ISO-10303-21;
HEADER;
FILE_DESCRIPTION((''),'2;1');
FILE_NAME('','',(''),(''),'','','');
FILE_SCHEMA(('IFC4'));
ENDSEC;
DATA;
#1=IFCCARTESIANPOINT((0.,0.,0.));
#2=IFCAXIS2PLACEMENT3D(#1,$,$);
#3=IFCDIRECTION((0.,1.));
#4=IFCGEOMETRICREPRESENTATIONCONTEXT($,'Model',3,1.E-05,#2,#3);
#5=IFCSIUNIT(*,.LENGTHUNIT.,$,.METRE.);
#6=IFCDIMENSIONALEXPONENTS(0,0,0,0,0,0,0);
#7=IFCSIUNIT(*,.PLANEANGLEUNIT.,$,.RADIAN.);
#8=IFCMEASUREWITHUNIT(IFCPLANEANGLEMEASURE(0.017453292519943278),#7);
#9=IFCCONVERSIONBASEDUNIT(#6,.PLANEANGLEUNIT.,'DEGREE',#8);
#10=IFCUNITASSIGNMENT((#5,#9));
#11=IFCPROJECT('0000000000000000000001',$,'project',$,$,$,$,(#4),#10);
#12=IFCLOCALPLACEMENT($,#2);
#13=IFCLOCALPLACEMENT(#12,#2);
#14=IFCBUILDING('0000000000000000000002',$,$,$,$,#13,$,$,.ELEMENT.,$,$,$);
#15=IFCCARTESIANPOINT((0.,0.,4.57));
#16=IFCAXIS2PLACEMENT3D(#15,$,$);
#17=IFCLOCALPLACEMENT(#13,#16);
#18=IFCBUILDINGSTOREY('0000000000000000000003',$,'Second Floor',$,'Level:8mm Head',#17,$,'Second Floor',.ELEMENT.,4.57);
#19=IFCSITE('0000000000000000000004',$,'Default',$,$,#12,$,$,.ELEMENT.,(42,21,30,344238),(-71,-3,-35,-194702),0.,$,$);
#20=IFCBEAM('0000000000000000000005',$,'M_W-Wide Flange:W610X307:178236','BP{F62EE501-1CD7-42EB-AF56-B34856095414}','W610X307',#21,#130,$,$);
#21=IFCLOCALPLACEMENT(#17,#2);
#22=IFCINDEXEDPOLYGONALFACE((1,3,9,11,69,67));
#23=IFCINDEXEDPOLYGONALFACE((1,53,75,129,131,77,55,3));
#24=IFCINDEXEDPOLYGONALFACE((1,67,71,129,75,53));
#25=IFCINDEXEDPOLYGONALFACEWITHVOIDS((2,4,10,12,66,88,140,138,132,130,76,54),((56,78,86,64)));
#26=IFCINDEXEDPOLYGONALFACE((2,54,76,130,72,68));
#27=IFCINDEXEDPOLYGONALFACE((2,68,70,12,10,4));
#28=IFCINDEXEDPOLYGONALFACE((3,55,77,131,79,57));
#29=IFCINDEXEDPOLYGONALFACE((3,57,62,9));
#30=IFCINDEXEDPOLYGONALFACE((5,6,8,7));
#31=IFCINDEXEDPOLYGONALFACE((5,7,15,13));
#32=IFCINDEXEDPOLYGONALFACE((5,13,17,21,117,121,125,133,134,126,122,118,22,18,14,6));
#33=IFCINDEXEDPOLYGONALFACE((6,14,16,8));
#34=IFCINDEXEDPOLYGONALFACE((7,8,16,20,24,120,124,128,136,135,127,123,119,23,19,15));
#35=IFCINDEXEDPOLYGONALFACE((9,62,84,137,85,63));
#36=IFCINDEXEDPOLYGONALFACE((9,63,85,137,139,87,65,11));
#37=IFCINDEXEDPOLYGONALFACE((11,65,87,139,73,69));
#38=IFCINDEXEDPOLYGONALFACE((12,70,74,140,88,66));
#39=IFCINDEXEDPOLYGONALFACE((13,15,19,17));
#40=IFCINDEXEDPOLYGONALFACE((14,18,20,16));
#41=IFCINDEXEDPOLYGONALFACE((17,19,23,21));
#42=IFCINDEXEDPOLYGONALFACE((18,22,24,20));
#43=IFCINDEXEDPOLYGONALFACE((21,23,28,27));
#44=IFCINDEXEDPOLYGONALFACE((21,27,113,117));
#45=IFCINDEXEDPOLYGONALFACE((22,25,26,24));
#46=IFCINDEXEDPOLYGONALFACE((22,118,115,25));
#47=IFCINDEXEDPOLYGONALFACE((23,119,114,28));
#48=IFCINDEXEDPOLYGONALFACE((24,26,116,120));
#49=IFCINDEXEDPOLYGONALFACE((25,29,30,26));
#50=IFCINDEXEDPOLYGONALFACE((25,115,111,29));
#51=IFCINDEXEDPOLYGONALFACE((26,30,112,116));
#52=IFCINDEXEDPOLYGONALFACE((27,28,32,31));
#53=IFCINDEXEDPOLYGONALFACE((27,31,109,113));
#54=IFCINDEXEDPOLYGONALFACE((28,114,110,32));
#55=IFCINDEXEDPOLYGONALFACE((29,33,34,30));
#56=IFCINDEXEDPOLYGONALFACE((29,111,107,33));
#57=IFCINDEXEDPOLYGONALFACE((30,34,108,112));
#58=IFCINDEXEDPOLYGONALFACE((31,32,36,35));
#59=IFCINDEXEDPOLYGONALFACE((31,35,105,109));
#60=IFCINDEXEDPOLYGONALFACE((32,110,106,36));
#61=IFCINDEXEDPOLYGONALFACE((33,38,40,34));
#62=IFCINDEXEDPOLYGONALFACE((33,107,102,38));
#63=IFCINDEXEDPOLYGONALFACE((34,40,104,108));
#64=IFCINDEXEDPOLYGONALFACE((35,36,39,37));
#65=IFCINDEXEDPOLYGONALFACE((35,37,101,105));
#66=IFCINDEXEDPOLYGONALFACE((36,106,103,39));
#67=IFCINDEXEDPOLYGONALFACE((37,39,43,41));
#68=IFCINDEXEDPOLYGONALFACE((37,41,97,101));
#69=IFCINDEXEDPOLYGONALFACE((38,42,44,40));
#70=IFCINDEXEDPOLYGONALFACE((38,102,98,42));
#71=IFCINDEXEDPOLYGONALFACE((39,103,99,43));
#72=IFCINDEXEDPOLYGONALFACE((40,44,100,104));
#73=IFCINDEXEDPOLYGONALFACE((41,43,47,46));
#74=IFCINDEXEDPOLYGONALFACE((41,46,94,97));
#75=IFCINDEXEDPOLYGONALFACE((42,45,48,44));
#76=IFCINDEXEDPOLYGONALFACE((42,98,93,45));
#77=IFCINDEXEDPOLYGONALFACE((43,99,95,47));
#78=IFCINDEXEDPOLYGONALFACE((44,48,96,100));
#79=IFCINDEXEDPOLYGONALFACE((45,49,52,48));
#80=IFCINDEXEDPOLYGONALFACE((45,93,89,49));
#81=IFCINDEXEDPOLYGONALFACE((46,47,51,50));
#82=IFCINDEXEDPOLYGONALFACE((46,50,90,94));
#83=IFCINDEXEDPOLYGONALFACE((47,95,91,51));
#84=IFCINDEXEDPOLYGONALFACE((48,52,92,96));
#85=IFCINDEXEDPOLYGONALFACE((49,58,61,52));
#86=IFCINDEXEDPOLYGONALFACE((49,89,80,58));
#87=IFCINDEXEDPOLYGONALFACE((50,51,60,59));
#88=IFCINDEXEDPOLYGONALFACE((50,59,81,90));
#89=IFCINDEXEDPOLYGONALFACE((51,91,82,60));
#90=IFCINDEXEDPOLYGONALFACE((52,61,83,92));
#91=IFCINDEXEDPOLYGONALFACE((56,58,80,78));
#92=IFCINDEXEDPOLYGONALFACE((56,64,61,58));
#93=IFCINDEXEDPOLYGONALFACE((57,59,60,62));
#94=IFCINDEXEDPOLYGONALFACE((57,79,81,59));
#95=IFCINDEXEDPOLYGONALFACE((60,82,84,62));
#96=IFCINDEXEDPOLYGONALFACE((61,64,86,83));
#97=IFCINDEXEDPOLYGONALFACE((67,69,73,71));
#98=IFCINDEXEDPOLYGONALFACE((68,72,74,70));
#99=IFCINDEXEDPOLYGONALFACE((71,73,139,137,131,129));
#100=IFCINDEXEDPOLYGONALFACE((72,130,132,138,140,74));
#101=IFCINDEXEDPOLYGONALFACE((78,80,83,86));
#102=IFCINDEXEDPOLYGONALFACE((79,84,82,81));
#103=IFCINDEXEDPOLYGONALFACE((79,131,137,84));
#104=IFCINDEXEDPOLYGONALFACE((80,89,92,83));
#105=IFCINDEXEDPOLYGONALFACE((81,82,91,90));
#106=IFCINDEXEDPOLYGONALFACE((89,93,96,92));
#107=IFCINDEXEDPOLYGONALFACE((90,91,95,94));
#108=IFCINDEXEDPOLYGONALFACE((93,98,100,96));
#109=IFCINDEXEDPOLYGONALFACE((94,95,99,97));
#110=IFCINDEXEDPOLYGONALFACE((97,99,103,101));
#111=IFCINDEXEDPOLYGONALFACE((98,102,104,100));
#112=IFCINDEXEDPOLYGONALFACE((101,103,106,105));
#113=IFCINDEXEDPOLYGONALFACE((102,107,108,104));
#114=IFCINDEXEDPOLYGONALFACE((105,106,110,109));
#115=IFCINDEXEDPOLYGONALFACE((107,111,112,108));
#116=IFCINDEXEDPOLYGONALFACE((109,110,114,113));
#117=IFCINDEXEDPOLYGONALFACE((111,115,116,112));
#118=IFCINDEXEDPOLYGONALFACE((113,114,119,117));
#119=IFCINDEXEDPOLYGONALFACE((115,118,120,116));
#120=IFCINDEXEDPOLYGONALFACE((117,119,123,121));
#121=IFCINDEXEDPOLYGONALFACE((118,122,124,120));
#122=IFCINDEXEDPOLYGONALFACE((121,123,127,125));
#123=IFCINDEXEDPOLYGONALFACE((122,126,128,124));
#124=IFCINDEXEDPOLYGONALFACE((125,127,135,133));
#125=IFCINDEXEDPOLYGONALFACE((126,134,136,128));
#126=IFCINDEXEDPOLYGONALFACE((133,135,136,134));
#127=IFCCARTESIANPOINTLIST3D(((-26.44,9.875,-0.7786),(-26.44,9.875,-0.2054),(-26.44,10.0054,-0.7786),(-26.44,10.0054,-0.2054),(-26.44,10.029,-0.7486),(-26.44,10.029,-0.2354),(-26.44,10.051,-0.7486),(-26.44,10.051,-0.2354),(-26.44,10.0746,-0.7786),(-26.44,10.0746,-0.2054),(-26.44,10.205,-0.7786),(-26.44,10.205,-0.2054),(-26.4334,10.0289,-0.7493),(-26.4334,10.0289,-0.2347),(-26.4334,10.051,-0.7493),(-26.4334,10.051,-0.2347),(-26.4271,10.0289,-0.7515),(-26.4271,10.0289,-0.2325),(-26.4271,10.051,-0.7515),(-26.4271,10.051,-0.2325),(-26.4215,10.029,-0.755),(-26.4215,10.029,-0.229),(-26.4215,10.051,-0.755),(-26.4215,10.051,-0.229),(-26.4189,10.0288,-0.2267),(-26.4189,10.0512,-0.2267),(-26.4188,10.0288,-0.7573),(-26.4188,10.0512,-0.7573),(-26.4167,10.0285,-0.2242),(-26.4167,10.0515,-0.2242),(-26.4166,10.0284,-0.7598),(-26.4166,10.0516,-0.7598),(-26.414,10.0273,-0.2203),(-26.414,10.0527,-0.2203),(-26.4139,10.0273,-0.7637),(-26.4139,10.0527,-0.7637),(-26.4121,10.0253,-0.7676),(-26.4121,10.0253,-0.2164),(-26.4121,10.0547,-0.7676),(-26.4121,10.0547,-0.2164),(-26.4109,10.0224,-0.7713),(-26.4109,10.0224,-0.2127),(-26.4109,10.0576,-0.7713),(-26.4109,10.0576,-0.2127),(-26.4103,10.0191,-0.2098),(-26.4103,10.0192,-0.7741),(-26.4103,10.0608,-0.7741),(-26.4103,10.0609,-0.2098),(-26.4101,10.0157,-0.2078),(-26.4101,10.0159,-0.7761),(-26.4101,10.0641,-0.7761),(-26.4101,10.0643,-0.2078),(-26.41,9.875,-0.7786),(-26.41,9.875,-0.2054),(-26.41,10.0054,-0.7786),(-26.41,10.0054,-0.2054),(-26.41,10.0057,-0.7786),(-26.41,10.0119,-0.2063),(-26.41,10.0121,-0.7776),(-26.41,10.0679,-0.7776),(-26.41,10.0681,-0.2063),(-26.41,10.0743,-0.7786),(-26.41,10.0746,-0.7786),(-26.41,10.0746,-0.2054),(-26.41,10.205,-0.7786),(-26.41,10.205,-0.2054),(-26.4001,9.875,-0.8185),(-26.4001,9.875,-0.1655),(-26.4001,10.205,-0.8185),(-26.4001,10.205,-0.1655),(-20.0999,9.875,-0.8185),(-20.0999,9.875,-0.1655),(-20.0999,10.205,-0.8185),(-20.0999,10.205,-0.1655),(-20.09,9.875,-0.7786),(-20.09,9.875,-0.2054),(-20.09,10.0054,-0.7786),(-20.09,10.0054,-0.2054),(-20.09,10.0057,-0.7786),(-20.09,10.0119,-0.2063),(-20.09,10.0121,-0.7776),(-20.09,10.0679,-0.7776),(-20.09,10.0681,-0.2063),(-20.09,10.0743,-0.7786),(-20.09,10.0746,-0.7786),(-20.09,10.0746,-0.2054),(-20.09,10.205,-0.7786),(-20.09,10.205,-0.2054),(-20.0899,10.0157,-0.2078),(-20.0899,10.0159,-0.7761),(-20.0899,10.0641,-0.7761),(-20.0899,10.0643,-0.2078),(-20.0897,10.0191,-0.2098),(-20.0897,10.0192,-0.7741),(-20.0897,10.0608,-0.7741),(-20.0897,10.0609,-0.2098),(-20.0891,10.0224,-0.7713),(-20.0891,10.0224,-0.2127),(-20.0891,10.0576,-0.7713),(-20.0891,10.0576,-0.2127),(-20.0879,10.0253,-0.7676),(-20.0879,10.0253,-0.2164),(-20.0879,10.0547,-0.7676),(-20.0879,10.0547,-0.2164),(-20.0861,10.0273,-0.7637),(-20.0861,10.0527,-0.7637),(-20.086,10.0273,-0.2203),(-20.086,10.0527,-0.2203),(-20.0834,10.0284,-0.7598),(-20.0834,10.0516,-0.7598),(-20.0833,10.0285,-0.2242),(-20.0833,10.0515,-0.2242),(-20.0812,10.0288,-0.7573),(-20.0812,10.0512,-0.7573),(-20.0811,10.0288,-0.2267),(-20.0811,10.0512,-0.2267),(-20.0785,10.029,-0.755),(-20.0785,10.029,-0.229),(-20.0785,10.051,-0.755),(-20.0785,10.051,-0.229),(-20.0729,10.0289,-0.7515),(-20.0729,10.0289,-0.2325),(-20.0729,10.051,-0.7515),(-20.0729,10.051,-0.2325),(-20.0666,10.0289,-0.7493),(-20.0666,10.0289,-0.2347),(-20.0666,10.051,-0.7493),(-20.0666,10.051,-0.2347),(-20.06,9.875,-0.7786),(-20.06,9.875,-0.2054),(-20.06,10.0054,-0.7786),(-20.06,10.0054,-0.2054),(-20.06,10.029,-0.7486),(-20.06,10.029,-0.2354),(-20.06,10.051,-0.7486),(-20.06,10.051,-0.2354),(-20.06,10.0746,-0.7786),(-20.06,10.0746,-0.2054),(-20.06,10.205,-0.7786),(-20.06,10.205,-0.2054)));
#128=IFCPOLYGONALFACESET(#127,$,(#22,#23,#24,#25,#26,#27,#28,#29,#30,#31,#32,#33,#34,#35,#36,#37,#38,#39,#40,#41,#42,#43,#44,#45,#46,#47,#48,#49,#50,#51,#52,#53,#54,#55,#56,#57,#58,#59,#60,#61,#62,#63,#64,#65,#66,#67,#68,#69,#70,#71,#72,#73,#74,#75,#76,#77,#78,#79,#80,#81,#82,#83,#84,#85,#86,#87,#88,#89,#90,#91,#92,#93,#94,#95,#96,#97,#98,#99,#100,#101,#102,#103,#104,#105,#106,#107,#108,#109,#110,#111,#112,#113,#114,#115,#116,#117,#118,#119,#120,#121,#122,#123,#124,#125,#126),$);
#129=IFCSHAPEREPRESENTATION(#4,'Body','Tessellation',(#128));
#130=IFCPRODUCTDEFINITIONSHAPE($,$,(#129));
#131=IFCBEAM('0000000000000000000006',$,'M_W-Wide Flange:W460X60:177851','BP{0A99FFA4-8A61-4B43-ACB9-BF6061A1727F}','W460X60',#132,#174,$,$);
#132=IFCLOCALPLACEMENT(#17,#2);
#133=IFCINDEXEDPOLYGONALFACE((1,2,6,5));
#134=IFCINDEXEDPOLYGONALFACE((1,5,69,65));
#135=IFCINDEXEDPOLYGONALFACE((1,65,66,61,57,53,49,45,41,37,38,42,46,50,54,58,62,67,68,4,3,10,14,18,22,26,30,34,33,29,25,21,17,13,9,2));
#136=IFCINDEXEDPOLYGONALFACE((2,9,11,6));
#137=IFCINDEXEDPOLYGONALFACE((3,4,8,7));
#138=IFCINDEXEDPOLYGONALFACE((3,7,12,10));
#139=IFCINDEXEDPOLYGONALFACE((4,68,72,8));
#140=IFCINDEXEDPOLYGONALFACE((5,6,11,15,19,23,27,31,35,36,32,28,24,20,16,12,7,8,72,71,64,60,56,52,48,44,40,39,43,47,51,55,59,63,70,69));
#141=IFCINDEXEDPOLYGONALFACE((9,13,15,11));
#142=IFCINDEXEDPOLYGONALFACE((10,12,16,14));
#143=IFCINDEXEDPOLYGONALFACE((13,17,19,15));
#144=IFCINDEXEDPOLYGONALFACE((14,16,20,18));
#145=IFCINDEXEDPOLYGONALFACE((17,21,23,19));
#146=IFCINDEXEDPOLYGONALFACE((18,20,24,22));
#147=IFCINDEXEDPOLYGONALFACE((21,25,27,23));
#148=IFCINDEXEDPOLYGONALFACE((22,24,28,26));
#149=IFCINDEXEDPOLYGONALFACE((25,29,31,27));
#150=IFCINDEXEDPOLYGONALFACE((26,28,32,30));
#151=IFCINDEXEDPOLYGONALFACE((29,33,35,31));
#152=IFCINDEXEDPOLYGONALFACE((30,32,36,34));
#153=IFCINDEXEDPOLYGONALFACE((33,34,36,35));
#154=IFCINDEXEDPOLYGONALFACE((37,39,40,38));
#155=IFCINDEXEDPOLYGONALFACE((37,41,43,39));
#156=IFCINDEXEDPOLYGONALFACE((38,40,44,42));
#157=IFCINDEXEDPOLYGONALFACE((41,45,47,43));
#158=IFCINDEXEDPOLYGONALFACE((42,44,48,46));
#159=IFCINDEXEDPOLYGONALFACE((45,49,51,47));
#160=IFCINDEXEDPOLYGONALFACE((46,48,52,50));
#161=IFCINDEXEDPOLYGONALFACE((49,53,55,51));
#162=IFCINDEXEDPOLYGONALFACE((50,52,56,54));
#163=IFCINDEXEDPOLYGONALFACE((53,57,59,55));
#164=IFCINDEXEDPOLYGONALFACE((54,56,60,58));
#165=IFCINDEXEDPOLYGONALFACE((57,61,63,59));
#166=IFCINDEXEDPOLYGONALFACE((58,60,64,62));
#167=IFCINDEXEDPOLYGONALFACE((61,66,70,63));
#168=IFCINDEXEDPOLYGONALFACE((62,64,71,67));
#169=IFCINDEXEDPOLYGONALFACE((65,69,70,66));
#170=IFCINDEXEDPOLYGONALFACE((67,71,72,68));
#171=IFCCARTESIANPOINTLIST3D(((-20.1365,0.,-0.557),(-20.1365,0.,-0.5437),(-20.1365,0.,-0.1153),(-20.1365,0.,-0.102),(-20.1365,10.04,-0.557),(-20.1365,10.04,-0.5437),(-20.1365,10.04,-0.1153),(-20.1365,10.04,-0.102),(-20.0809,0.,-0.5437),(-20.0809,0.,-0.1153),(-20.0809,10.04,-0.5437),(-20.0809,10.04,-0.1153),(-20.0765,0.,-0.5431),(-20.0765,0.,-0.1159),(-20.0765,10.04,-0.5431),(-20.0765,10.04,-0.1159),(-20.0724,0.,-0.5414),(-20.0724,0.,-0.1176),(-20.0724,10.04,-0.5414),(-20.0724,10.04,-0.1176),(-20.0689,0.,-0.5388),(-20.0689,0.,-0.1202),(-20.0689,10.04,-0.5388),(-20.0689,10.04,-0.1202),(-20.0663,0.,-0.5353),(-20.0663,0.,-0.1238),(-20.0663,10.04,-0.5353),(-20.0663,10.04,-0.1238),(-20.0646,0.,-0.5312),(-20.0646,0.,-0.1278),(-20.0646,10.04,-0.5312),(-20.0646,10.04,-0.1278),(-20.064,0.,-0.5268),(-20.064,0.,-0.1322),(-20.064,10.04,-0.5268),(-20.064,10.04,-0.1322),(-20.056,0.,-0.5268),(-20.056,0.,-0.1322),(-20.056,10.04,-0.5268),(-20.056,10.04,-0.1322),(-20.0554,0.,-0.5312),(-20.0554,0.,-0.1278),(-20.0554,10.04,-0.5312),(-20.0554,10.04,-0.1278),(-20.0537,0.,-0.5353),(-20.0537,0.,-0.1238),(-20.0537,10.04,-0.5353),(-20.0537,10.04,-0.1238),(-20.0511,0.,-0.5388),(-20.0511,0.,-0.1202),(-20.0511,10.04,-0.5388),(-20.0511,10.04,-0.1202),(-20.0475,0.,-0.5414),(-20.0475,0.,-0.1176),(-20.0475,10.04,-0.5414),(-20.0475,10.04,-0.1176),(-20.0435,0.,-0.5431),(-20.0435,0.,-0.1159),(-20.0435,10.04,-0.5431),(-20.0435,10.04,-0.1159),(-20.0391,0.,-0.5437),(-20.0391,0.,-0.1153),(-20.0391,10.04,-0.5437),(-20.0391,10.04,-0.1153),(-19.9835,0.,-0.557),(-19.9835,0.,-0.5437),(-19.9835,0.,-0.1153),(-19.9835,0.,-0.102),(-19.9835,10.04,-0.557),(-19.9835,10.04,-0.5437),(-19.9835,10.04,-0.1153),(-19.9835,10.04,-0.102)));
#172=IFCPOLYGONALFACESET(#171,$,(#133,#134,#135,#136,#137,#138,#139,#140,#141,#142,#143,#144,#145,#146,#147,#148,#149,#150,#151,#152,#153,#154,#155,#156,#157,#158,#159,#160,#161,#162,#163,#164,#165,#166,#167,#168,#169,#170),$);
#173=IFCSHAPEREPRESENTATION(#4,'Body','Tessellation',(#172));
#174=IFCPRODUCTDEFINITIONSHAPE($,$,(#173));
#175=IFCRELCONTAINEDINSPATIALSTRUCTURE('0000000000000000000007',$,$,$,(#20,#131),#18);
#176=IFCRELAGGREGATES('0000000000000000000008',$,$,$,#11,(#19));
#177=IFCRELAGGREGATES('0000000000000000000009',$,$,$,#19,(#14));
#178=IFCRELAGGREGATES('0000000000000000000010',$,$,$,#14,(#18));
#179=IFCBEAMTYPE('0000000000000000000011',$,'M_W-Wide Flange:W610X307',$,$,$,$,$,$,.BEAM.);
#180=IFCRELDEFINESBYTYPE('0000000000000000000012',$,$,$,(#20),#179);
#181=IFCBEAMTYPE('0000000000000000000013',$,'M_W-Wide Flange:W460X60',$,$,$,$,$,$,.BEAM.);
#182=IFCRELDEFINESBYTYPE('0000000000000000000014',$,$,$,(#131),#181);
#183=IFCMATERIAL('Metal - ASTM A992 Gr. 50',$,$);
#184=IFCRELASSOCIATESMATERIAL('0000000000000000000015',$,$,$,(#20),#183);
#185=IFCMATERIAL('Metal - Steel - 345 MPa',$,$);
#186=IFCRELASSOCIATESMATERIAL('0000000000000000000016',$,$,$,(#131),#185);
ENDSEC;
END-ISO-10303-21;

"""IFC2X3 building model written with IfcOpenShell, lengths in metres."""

from ifc_helpers import new_model, entity, si_unit, converted_unit, point, direction, frame, frame_2d, origin, origin_2d, place, context, project, spatial, polyline, circle_curve, line_curve, trimmed, segment, composite_curve, i_section, outline, extrude, material, type_object, element, save


model = new_model("IFC2X3")

# Units and contexts
model_context = context("Model", 3, precision=1e-05, world=origin(), true_north=direction((0.0, 1.0)))
ifc_project = project(units=[si_unit("LENGTHUNIT", "METRE"), converted_unit("PLANEANGLEUNIT", "DEGREE", entity("IfcPlaneAngleMeasure", 0.017453292519943278), si_unit("PLANEANGLEUNIT", "RADIAN"), dimensions=[0, 0, 0, 0, 0, 0, 0])], contexts=[model_context])

# Site, building, storey
site_placement = place(None, origin())
site = spatial("IfcSite", under=ifc_project, at=site_placement, Name="Default", CompositionType="ELEMENT", RefLatitude=(42, 21, 30, 344238), RefLongitude=(-71, -3, -35, -194702), RefElevation=0.0)
building_placement = place(site_placement, origin())
building = spatial("IfcBuilding", under=site, at=building_placement, CompositionType="ELEMENT")
storey_placement = place(building_placement, frame((0.0, 0.0, 4.57)))
storey = spatial("IfcBuildingStorey", under=building, at=storey_placement, Name="Second Floor", ObjectType="Level:8mm Head", LongName="Second Floor", CompositionType="ELEMENT", Elevation=4.57)

# Shared definitions
ifc_material_1 = material(Name="Metal - ASTM A992 Gr. 50")

# Shared definitions
ifc_material_2 = material(Name="Metal - Steel - 345 MPa")

# Beam, openings
beam_type_1 = type_object("IfcBeamType", Name="M_W-Wide Flange:W610X307", PredefinedType="BEAM")
beam_1_placement = place(storey_placement, frame((-20.06, 10.04, -0.492), z_axis=(1.0, 0.0, 0.0), x_axis=(0.0, 1.0, 0.0)))
beam_1 = element("IfcBeam", 1, at=beam_1_placement, inside=storey, type_object=beam_type_1, material=ifc_material_1, Name="M_W-Wide Flange:W610X307:178236", Description="BP{F62EE501-1CD7-42EB-AF56-B34856095414}", ObjectType="W610X307", context=model_context, shape_type="SweptSolid", body=[
    extrude(i_section(OverallWidth=0.33, OverallDepth=0.653, WebThickness=0.0221, FlangeThickness=0.0399, FilletRadius=0.0236, at=origin_2d()), origin(), (0.0, 0.0, -1.0), 6.38),
])
opening_1_placement = place(beam_1_placement, frame((-0.2651, 0.3265, -6.38), z_axis=(1.0, 0.0, 0.0), x_axis=(0.0, 0.0, -1.0)))
element("IfcOpeningElement", 2, at=opening_1_placement, cuts=beam_1, ObjectType="Opening", context=model_context, shape_type="SweptSolid", body=[
    extrude(outline(polyline([(0.0, -0.0399), (0.0, 0.0), (-0.0399, 0.0), (0.0, -0.0399)])), origin(), (0.0, 0.0, 1.0), 0.5302),
])
opening_2_placement = place(beam_1_placement, frame((0.2651, 0.3265, -6.38), z_axis=(-1.0, 0.0, 0.0), x_axis=(0.0, 0.0, 1.0)))
element("IfcOpeningElement", 3, at=opening_2_placement, cuts=beam_1, ObjectType="Opening", context=model_context, shape_type="SweptSolid", body=[
    extrude(outline(polyline([(0.0, -0.6131), (0.0, -0.653), (0.0399, -0.653), (0.0, -0.6131)])), origin(), (0.0, 0.0, 1.0), 0.5302),
])
opening_3_placement = place(beam_1_placement, frame((-0.2651, 0.3265, -6.38), z_axis=(1.0, 0.0, 0.0), x_axis=(0.0, 0.0, -1.0)))
element("IfcOpeningElement", 4, at=opening_3_placement, cuts=beam_1, ObjectType="Opening", context=model_context, shape_type="SweptSolid", body=[
    extrude(outline(composite_curve([segment(trimmed(circle_curve(frame_2d((0.0, -0.0399), x_axis=(1.0, 0.0)), 0.03), [point((-0.03, -0.0399))], [point((0.03, -0.0399))], True, "CARTESIAN"), True, "CONTINUOUS"), segment(trimmed(line_curve((0.03, -0.0399), (-1.0, 0.0), 0.06), [point((0.03, -0.0399))], [point((-0.03, -0.0399))], True, "CARTESIAN"), True, "CONTINUOUS")], self_intersect="UNKNOWN")), origin(), (0.0, 0.0, 1.0), 0.5302),
])
opening_4_placement = place(beam_1_placement, frame((0.2651, 0.3265, -6.38), z_axis=(-1.0, 0.0, 0.0), x_axis=(0.0, 0.0, 1.0)))
element("IfcOpeningElement", 5, at=opening_4_placement, cuts=beam_1, ObjectType="Opening", context=model_context, shape_type="SweptSolid", body=[
    extrude(outline(composite_curve([segment(trimmed(circle_curve(frame_2d((0.0, -0.6131), x_axis=(1.0, 0.0)), 0.03), [point((0.03, -0.6131))], [point((-0.03, -0.6131))], True, "CARTESIAN"), True, "CONTINUOUS"), segment(trimmed(line_curve((-0.03, -0.6131), (1.0, 0.0), 0.06), [point((-0.03, -0.6131))], [point((0.03, -0.6131))], True, "CARTESIAN"), True, "CONTINUOUS")], self_intersect="UNKNOWN")), origin(), (0.0, 0.0, 1.0), 0.5302),
])
opening_5_placement = place(beam_1_placement, frame((0.2651, 0.3265, 0.0), z_axis=(-1.0, 0.0, 0.0), x_axis=(0.0, 0.0, 1.0)))
element("IfcOpeningElement", 6, at=opening_5_placement, cuts=beam_1, ObjectType="Opening", context=model_context, shape_type="SweptSolid", body=[
    extrude(outline(polyline([(0.0, -0.0399), (0.0, 0.0), (-0.0399, 0.0), (0.0, -0.0399)])), origin(), (0.0, 0.0, 1.0), 0.5302),
])
opening_6_placement = place(beam_1_placement, frame((-0.2651, 0.3265, 0.0), z_axis=(1.0, 0.0, 0.0), x_axis=(0.0, 0.0, -1.0)))
element("IfcOpeningElement", 7, at=opening_6_placement, cuts=beam_1, ObjectType="Opening", context=model_context, shape_type="SweptSolid", body=[
    extrude(outline(polyline([(0.0, -0.6131), (0.0, -0.653), (0.0399, -0.653), (0.0, -0.6131)])), origin(), (0.0, 0.0, 1.0), 0.5302),
])
opening_7_placement = place(beam_1_placement, frame((0.2651, 0.3265, 0.0), z_axis=(-1.0, 0.0, 0.0), x_axis=(0.0, 0.0, 1.0)))
element("IfcOpeningElement", 8, at=opening_7_placement, cuts=beam_1, ObjectType="Opening", context=model_context, shape_type="SweptSolid", body=[
    extrude(outline(composite_curve([segment(trimmed(circle_curve(frame_2d((0.0, -0.0399), x_axis=(1.0, 0.0)), 0.03), [point((-0.03, -0.0399))], [point((0.03, -0.0399))], True, "CARTESIAN"), True, "CONTINUOUS"), segment(trimmed(line_curve((0.03, -0.0399), (-1.0, 0.0), 0.06), [point((0.03, -0.0399))], [point((-0.03, -0.0399))], True, "CARTESIAN"), True, "CONTINUOUS")], self_intersect="UNKNOWN")), origin(), (0.0, 0.0, 1.0), 0.5302),
])
opening_8_placement = place(beam_1_placement, frame((-0.2651, 0.3265, 0.0), z_axis=(1.0, 0.0, 0.0), x_axis=(0.0, 0.0, -1.0)))
element("IfcOpeningElement", 9, at=opening_8_placement, cuts=beam_1, ObjectType="Opening", context=model_context, shape_type="SweptSolid", body=[
    extrude(outline(composite_curve([segment(trimmed(circle_curve(frame_2d((0.0, -0.6131), x_axis=(1.0, 0.0)), 0.03), [point((0.03, -0.6131))], [point((-0.03, -0.6131))], True, "CARTESIAN"), True, "CONTINUOUS"), segment(trimmed(line_curve((-0.03, -0.6131), (1.0, 0.0), 0.06), [point((-0.03, -0.6131))], [point((0.03, -0.6131))], True, "CARTESIAN"), True, "CONTINUOUS")], self_intersect="UNKNOWN")), origin(), (0.0, 0.0, 1.0), 0.5302),
])

# Beam
beam_type_2 = type_object("IfcBeamType", Name="M_W-Wide Flange:W460X60", PredefinedType="BEAM")
beam_2_placement = place(storey_placement, frame((-20.06, 0.0, -0.3295), z_axis=(0.0, -1.0, 0.0), x_axis=(1.0, 0.0, 0.0)))
element("IfcBeam", 10, at=beam_2_placement, inside=storey, type_object=beam_type_2, material=ifc_material_2, Name="M_W-Wide Flange:W460X60:177851", Description="BP{0A99FFA4-8A61-4B43-ACB9-BF6061A1727F}", ObjectType="W460X60", context=model_context, shape_type="SweptSolid", body=[
    extrude(i_section(OverallWidth=0.153, OverallDepth=0.455, WebThickness=0.008, FlangeThickness=0.0133, FilletRadius=0.0169, at=origin_2d()), origin(), (0.0, 0.0, -1.0), 10.04),
])

save(model, "model.ifc")
